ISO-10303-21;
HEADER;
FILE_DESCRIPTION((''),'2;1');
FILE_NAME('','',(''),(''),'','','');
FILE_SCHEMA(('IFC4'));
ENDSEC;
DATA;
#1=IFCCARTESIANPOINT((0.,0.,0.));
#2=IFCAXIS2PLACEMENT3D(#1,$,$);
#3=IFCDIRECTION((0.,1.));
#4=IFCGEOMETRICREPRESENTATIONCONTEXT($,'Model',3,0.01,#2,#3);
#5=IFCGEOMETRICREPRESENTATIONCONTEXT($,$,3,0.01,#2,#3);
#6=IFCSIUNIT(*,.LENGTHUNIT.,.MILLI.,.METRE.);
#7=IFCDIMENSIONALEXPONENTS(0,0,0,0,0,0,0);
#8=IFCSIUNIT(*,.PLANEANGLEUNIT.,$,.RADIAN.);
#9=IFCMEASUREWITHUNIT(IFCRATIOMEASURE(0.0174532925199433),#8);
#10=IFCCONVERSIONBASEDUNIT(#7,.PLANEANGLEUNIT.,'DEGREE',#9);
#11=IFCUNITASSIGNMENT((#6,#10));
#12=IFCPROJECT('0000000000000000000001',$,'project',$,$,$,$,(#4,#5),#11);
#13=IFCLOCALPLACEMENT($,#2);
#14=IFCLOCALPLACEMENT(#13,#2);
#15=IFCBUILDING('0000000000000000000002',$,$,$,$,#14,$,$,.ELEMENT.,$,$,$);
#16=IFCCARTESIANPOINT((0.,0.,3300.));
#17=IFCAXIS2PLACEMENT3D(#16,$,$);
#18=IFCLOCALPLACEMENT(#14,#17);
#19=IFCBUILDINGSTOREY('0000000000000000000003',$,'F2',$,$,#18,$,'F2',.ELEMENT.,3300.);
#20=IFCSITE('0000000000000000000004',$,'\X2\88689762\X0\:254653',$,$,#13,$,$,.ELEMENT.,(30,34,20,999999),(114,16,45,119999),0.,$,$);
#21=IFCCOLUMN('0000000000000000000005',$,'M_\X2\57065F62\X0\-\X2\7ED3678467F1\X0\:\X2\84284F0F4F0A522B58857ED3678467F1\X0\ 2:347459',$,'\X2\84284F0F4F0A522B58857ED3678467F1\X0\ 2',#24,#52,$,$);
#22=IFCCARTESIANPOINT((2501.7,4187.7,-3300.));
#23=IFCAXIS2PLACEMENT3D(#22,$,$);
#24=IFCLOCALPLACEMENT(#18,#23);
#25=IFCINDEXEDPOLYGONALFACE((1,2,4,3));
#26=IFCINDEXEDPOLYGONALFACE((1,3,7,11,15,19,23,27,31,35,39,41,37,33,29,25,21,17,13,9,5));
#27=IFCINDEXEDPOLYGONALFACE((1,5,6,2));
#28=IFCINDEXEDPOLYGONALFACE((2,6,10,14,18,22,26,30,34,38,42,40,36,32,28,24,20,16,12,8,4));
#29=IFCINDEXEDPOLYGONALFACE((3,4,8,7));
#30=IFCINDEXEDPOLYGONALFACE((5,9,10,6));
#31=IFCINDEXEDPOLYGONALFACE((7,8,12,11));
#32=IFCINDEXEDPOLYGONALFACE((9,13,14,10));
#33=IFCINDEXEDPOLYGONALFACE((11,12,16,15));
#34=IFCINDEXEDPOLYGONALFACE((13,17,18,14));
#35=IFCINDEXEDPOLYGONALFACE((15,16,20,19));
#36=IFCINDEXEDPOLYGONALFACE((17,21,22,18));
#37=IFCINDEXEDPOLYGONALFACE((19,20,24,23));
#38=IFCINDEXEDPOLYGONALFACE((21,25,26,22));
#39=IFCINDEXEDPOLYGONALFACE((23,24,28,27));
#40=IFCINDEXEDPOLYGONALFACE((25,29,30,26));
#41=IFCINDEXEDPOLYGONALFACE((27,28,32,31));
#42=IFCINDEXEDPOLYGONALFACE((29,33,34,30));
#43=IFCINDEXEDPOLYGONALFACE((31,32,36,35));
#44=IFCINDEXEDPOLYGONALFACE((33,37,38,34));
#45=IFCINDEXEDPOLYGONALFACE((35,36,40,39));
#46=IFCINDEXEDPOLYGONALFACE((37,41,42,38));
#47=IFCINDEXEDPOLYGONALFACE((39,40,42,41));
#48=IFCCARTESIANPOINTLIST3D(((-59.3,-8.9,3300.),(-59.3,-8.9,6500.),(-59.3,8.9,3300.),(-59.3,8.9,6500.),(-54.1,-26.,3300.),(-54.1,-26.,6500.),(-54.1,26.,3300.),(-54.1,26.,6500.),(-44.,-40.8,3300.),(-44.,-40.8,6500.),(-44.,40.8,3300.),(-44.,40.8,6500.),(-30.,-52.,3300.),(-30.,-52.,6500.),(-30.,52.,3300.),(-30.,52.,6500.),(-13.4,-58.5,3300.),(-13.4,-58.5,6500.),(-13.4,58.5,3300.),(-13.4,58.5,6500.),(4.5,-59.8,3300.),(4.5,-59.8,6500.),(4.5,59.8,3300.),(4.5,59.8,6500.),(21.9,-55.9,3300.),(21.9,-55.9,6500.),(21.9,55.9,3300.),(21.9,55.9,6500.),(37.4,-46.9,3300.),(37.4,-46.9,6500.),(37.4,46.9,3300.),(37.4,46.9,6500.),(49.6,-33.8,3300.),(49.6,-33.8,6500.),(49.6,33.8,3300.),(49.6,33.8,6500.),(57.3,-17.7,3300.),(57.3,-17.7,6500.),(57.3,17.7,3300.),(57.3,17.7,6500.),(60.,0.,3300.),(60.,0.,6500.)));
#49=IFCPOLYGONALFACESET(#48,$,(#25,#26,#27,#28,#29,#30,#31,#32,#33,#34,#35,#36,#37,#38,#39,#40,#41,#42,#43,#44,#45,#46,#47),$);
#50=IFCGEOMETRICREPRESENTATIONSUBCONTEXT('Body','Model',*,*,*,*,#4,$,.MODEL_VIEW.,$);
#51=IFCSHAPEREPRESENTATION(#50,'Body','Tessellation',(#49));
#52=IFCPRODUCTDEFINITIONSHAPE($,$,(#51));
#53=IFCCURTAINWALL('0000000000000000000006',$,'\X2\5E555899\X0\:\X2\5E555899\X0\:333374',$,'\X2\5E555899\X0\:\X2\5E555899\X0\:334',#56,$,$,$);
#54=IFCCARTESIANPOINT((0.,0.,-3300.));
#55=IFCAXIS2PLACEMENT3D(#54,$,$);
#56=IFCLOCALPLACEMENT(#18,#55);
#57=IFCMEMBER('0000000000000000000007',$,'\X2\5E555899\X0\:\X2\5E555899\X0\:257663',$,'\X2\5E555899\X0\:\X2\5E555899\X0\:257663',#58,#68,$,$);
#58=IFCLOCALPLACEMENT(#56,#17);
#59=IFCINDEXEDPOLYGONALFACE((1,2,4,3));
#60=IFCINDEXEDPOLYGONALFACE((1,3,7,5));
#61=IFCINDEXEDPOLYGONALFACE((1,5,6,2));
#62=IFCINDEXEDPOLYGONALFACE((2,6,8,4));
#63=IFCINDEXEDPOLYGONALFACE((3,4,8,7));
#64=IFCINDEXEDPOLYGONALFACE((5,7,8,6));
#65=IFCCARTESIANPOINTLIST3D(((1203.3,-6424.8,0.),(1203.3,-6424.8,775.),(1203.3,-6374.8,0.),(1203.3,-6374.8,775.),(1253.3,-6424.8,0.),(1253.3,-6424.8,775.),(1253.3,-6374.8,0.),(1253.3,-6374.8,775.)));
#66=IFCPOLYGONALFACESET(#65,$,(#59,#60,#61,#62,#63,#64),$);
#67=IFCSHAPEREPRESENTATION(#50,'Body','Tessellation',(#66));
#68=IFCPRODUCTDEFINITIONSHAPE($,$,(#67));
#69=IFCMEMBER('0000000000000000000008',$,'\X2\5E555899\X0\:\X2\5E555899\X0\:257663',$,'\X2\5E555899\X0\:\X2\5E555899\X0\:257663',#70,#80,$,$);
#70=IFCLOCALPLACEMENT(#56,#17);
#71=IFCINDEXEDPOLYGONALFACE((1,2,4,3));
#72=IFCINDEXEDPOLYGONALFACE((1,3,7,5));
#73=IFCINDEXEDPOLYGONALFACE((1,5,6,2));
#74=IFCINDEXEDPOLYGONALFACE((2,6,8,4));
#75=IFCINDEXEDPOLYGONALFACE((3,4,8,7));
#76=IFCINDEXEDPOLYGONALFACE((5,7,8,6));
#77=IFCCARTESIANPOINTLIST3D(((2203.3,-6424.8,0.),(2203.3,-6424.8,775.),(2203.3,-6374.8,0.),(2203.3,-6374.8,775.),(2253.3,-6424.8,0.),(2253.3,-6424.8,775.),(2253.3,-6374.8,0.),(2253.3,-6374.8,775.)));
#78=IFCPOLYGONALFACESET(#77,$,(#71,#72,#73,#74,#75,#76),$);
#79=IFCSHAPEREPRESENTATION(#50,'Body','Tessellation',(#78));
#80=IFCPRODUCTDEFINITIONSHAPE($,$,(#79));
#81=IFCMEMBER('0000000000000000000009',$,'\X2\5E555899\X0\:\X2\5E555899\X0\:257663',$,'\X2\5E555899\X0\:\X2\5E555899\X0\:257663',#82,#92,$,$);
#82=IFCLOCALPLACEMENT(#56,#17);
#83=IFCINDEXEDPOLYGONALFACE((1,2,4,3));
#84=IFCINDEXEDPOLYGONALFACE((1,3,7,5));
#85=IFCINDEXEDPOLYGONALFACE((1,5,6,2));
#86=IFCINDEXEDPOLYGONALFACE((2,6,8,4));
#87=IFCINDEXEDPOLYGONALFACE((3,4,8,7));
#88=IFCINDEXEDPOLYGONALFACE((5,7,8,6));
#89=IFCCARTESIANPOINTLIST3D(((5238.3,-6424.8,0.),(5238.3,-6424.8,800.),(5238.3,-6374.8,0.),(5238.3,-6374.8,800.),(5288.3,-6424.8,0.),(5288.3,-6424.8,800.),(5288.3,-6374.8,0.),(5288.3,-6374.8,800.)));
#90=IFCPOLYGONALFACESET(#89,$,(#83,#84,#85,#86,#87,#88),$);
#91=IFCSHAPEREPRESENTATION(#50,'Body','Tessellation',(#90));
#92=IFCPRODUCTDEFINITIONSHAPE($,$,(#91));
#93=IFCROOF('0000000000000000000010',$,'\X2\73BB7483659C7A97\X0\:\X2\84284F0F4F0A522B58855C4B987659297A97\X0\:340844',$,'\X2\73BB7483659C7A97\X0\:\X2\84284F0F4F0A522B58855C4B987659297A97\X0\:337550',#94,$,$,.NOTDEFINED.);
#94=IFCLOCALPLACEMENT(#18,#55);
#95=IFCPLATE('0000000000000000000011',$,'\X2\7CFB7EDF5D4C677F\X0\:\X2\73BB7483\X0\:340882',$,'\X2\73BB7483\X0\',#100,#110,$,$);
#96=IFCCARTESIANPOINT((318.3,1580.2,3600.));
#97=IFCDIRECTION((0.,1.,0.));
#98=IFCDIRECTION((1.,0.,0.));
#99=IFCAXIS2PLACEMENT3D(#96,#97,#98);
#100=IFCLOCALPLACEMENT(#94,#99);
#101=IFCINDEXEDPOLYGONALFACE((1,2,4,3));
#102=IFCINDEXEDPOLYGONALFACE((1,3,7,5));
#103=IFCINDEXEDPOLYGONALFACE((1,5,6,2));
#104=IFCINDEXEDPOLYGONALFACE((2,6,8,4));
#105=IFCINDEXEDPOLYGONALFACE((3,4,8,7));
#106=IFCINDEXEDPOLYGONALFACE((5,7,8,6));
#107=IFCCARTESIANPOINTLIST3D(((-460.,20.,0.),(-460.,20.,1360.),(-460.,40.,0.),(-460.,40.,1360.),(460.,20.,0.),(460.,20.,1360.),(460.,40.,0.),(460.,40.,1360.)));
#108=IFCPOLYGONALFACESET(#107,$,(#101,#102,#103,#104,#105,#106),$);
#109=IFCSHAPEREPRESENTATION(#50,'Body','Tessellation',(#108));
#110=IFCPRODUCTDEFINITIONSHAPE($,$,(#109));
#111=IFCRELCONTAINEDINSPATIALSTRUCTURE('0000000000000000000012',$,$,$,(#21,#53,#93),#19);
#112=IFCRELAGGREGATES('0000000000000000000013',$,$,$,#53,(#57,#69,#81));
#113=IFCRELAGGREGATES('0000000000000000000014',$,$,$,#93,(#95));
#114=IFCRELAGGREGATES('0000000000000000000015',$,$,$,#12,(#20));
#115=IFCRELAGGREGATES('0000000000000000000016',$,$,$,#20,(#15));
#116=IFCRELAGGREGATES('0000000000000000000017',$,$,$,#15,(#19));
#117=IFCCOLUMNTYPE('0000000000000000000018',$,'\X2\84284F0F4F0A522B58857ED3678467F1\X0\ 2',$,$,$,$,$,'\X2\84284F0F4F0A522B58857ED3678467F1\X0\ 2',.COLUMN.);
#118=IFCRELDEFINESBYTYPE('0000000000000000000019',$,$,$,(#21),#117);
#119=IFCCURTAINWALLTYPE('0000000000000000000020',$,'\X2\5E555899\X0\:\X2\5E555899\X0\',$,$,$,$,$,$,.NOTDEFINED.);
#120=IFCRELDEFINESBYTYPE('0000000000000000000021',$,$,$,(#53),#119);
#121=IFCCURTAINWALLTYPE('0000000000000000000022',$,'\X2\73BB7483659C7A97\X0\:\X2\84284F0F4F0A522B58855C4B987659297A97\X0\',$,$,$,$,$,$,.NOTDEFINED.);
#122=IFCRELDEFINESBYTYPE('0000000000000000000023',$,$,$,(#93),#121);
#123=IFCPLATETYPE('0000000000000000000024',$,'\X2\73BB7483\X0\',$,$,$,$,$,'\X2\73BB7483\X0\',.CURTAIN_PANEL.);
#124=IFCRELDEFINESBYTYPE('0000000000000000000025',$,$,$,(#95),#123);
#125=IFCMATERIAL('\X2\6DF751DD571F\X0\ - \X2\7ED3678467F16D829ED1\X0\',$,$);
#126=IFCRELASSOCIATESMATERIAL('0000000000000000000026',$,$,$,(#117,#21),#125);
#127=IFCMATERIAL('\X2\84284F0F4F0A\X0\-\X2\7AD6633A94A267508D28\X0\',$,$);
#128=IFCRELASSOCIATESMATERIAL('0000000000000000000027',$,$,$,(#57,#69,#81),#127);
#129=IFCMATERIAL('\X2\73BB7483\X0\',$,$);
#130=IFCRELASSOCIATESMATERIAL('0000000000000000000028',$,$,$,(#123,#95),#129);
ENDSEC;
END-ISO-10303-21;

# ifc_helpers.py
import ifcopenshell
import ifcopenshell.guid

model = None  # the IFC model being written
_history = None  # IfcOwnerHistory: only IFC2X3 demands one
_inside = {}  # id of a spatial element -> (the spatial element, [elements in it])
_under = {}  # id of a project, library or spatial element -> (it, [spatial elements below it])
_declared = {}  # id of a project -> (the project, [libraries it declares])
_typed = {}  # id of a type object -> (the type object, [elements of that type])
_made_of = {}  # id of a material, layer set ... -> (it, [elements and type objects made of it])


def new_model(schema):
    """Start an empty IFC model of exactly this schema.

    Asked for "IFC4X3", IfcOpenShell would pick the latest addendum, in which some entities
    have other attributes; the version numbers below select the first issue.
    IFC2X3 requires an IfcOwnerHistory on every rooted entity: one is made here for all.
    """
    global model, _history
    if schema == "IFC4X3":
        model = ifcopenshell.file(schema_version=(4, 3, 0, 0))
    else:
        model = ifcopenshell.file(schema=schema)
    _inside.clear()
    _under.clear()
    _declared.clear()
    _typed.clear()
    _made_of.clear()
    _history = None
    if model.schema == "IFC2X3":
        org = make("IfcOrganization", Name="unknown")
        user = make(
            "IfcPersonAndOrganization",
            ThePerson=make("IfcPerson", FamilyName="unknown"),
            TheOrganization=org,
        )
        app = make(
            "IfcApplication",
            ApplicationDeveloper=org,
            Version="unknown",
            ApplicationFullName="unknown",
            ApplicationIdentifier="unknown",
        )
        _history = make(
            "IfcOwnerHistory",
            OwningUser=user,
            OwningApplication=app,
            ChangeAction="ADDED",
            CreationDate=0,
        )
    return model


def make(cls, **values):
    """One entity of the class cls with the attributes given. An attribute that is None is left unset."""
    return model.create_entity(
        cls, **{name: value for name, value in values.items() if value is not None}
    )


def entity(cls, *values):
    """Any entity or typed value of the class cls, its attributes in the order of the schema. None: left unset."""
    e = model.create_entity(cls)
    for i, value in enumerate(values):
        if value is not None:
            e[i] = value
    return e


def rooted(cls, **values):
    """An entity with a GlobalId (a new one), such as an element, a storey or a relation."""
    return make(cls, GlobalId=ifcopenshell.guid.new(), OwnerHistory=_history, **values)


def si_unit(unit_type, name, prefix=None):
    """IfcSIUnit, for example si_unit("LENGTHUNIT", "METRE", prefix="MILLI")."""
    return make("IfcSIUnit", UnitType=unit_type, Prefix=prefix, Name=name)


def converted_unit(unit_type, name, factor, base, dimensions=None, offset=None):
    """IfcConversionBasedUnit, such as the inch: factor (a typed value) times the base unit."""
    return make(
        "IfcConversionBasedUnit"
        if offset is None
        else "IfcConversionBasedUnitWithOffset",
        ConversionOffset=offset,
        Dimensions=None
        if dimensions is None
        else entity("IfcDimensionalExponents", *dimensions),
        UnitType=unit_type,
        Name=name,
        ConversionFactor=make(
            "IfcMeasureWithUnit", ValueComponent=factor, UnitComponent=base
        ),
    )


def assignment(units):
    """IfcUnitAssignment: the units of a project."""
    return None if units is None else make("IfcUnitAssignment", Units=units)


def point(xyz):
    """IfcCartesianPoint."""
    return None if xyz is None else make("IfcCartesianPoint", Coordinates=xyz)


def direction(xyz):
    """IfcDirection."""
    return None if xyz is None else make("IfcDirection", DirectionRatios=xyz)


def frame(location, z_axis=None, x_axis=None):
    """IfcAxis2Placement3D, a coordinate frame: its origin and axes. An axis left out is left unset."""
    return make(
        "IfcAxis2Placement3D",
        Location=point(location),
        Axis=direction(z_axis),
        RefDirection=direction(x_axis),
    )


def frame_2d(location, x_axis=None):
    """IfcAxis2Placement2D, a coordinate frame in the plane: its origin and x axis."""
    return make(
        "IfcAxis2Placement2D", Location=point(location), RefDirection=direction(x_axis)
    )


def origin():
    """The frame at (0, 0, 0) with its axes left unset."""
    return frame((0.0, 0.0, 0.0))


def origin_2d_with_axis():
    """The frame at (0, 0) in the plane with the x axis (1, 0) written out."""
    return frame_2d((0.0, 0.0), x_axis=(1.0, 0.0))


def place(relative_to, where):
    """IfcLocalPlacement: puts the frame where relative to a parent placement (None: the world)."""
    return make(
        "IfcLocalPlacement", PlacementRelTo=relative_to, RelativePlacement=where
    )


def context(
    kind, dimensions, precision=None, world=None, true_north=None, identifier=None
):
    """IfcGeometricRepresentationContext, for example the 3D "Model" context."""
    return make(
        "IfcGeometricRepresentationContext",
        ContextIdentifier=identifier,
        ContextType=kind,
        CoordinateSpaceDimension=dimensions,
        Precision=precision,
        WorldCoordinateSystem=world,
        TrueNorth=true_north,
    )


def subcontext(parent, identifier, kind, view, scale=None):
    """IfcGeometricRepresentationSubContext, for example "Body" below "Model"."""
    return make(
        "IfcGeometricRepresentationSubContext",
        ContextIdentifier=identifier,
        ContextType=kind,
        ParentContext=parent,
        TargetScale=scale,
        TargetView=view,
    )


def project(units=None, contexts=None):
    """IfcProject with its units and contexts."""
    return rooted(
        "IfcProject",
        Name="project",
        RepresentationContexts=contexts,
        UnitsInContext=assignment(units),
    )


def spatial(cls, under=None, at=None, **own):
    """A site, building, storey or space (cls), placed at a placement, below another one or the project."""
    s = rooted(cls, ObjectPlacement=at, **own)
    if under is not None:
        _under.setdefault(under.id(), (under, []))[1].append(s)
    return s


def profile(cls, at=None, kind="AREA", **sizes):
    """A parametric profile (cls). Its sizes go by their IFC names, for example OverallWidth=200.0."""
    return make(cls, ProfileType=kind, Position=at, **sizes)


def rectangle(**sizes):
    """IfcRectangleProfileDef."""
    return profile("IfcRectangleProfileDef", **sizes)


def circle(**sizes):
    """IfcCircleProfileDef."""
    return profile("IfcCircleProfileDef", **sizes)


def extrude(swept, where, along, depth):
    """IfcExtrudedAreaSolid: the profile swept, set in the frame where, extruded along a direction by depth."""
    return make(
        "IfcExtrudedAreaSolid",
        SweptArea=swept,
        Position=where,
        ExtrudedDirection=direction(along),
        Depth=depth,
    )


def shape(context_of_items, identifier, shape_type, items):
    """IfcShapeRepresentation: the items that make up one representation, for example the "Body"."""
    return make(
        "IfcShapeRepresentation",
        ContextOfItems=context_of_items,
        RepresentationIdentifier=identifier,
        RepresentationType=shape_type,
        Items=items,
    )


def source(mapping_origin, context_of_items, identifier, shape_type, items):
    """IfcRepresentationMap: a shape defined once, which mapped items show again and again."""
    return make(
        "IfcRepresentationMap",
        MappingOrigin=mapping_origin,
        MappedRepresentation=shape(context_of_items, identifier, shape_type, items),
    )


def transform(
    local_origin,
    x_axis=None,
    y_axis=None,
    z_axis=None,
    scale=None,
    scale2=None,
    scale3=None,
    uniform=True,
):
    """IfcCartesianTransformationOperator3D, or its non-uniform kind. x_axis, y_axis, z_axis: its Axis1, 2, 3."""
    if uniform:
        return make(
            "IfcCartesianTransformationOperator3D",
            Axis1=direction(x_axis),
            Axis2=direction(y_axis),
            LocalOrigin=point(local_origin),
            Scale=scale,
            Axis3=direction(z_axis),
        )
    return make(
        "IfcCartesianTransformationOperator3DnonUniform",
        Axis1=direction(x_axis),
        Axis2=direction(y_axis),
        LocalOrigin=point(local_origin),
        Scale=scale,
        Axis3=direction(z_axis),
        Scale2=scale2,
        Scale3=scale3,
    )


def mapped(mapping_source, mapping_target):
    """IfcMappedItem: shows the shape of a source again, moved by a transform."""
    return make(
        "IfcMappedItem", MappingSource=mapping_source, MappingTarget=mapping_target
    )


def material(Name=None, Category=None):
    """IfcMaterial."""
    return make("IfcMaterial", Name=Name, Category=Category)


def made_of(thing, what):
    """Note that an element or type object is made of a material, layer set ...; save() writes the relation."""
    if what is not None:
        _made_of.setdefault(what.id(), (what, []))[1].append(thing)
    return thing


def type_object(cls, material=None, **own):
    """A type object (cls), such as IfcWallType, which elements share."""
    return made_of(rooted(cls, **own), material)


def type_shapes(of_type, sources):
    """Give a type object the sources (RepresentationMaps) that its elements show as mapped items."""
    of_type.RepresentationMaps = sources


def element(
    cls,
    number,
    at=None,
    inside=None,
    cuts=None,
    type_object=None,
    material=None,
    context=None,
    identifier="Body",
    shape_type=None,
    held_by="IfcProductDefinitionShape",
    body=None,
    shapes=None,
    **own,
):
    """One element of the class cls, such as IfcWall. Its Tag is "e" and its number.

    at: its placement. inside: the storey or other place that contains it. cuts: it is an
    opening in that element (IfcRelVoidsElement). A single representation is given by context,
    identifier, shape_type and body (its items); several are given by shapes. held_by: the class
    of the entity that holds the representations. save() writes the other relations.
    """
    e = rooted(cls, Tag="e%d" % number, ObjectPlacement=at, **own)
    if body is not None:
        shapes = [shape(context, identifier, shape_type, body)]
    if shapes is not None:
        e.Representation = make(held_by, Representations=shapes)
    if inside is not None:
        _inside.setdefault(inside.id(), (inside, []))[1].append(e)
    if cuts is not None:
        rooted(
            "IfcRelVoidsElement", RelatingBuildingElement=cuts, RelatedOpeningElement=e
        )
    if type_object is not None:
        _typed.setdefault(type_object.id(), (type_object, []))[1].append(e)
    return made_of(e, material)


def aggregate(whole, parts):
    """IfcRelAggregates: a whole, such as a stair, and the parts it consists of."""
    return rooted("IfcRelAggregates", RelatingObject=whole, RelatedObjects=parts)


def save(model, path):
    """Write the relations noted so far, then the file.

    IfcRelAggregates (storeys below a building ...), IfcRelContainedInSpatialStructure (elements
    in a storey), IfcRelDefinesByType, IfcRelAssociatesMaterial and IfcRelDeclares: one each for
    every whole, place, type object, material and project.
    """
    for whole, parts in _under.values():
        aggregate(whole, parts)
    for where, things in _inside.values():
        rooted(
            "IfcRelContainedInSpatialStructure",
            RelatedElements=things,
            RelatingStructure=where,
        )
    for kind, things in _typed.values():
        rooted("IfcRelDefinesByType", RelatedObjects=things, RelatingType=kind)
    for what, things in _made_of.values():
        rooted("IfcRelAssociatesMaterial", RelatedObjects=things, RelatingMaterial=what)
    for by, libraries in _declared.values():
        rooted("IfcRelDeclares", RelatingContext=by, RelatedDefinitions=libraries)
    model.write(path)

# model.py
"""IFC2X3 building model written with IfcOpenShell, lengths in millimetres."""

from ifc_helpers import new_model, entity, si_unit, converted_unit, direction, frame, frame_2d, origin, origin_2d_with_axis, place, context, subcontext, project, spatial, rectangle, circle, extrude, source, transform, mapped, material, type_object, type_shapes, element, aggregate, save


model = new_model("IFC2X3")

# Units and contexts
model_context = context("Model", 3, precision=0.01, world=origin(), true_north=direction((0.0, 1.0)))
context_of_model = context(None, 3, precision=0.01, world=origin(), true_north=direction((0.0, 1.0)))
body_context = subcontext(model_context, "Body", "Model", "MODEL_VIEW")
ifc_project = project(units=[si_unit("LENGTHUNIT", "METRE", prefix="MILLI"), converted_unit("PLANEANGLEUNIT", "DEGREE", entity("IfcRatioMeasure", 0.0174532925199433), si_unit("PLANEANGLEUNIT", "RADIAN"), dimensions=[0, 0, 0, 0, 0, 0, 0])], contexts=[model_context, context_of_model])

# Site, building, storey
site_placement = place(None, origin())
site = spatial("IfcSite", under=ifc_project, at=site_placement, Name="表面:254653", CompositionType="ELEMENT", RefLatitude=(30, 34, 20, 999999), RefLongitude=(114, 16, 45, 119999), RefElevation=0.0)
building_placement = place(site_placement, origin())
building = spatial("IfcBuilding", under=site, at=building_placement, CompositionType="ELEMENT")
storey_placement = place(building_placement, frame((0.0, 0.0, 3300.0)))
storey = spatial("IfcBuildingStorey", under=building, at=storey_placement, Name="F2", LongName="F2", CompositionType="ELEMENT", Elevation=3300.0)

# Column
ifc_material_1 = material(Name="混凝土 - 结构柱涂黑")
column_type = type_object("IfcColumnType", Name="萨伏伊别墅结构柱 2", ElementType="萨伏伊别墅结构柱 2", PredefinedType="COLUMN", material=ifc_material_1)
shared_shape_1 = source(origin(), body_context, "Body", "SweptSolid", [
    extrude(circle(Radius=60.0, at=frame_2d((0.0, 0.0), x_axis=(1.0, 0.0))), frame((0.0, 0.0, 3300.0)), (0.0, 0.0, 1.0), 3200.0),
])
type_shapes(column_type, [shared_shape_1])
column_placement = place(storey_placement, frame((2501.7, 4187.7, -3300.0)))
element("IfcColumn", 1, at=column_placement, inside=storey, type_object=column_type, material=ifc_material_1, Name="M_圆形-结构柱:萨伏伊别墅结构柱 2:347459", ObjectType="萨伏伊别墅结构柱 2", context=body_context, shape_type="MappedRepresentation", body=[
    mapped(shared_shape_1, transform((0.0, 0.0, 0.0), scale=1.0)),
])

# Curtain wall, members
curtain_wall_type_1 = type_object("IfcCurtainWallType", Name="幕墙:幕墙", PredefinedType="NOTDEFINED")
curtain_wall_placement = place(storey_placement, frame((0.0, 0.0, -3300.0)))
curtain_wall = element("IfcCurtainWall", 2, at=curtain_wall_placement, inside=storey, type_object=curtain_wall_type_1, Name="幕墙:幕墙:333374", ObjectType="幕墙:幕墙:334")
ifc_material_2 = material(Name="萨伏伊-竖挺钢材质")
member_1_placement = place(curtain_wall_placement, frame((0.0, 0.0, 3300.0)))
member_1 = element("IfcMember", 3, at=member_1_placement, material=ifc_material_2, Name="幕墙:幕墙:257663", ObjectType="幕墙:幕墙:257663", context=body_context, shape_type="SweptSolid", body=[
    extrude(rectangle(XDim=50.0, YDim=50.0, at=frame_2d((0.0, 0.0), x_axis=(1.0, 0.0))), frame((1228.3, -6399.8, 0.0), z_axis=(0.0, 0.0, 1.0), x_axis=(-1.0, 0.0, 0.0)), (0.0, 0.0, 1.0), 775.0),
])
member_2_placement = place(curtain_wall_placement, frame((0.0, 0.0, 3300.0)))
member_2 = element("IfcMember", 4, at=member_2_placement, material=ifc_material_2, Name="幕墙:幕墙:257663", ObjectType="幕墙:幕墙:257663", context=body_context, shape_type="SweptSolid", body=[
    extrude(rectangle(XDim=50.0, YDim=50.0, at=origin_2d_with_axis()), frame((2228.3, -6399.8, 0.0), z_axis=(0.0, 0.0, 1.0), x_axis=(-1.0, 0.0, 0.0)), (0.0, 0.0, 1.0), 775.0),
])
member_3_placement = place(curtain_wall_placement, frame((0.0, 0.0, 3300.0)))
member_3 = element("IfcMember", 5, at=member_3_placement, material=ifc_material_2, Name="幕墙:幕墙:257663", ObjectType="幕墙:幕墙:257663", context=body_context, shape_type="SweptSolid", body=[
    extrude(rectangle(XDim=50.0, YDim=50.0, at=origin_2d_with_axis()), frame((5263.3, -6399.8, 0.0), z_axis=(0.0, 0.0, 1.0), x_axis=(-1.0, 0.0, 0.0)), (0.0, 0.0, 1.0), 800.0),
])
aggregate(curtain_wall, [member_1, member_2, member_3])

# Roof, plate
curtain_wall_type_2 = type_object("IfcCurtainWallType", Name="玻璃斜窗:萨伏伊别墅屋顶天窗", PredefinedType="NOTDEFINED")
roof_placement = place(storey_placement, frame((0.0, 0.0, -3300.0)))
roof = element("IfcRoof", 6, at=roof_placement, inside=storey, type_object=curtain_wall_type_2, Name="玻璃斜窗:萨伏伊别墅屋顶天窗:340844", ObjectType="玻璃斜窗:萨伏伊别墅屋顶天窗:337550", ShapeType="NOTDEFINED")
ifc_material_3 = material(Name="玻璃")
plate_type = type_object("IfcPlateType", Name="玻璃", ElementType="玻璃", PredefinedType="CURTAIN_PANEL", material=ifc_material_3)
shared_shape_2 = source(origin(), body_context, "Body", "SweptSolid", [
    extrude(rectangle(XDim=20.0, YDim=920.0, at=frame_2d((0.0, 0.0), x_axis=(1.0, 0.0))), frame((0.0, 30.0, 0.0), z_axis=(0.0, 0.0, 1.0), x_axis=(0.0, 1.0, 0.0)), (0.0, 0.0, 1.0), 1360.0),
])
type_shapes(plate_type, [shared_shape_2])
plate_placement = place(roof_placement, frame((318.3, 1580.2, 3600.0), z_axis=(0.0, 1.0, 0.0), x_axis=(1.0, 0.0, 0.0)))
plate = element("IfcPlate", 7, at=plate_placement, type_object=plate_type, material=ifc_material_3, Name="系统嵌板:玻璃:340882", ObjectType="玻璃", context=body_context, shape_type="MappedRepresentation", body=[
    mapped(shared_shape_2, transform((0.0, 0.0, 0.0), scale=1.0)),
])
aggregate(roof, [plate])

save(model, "model.ifc")
